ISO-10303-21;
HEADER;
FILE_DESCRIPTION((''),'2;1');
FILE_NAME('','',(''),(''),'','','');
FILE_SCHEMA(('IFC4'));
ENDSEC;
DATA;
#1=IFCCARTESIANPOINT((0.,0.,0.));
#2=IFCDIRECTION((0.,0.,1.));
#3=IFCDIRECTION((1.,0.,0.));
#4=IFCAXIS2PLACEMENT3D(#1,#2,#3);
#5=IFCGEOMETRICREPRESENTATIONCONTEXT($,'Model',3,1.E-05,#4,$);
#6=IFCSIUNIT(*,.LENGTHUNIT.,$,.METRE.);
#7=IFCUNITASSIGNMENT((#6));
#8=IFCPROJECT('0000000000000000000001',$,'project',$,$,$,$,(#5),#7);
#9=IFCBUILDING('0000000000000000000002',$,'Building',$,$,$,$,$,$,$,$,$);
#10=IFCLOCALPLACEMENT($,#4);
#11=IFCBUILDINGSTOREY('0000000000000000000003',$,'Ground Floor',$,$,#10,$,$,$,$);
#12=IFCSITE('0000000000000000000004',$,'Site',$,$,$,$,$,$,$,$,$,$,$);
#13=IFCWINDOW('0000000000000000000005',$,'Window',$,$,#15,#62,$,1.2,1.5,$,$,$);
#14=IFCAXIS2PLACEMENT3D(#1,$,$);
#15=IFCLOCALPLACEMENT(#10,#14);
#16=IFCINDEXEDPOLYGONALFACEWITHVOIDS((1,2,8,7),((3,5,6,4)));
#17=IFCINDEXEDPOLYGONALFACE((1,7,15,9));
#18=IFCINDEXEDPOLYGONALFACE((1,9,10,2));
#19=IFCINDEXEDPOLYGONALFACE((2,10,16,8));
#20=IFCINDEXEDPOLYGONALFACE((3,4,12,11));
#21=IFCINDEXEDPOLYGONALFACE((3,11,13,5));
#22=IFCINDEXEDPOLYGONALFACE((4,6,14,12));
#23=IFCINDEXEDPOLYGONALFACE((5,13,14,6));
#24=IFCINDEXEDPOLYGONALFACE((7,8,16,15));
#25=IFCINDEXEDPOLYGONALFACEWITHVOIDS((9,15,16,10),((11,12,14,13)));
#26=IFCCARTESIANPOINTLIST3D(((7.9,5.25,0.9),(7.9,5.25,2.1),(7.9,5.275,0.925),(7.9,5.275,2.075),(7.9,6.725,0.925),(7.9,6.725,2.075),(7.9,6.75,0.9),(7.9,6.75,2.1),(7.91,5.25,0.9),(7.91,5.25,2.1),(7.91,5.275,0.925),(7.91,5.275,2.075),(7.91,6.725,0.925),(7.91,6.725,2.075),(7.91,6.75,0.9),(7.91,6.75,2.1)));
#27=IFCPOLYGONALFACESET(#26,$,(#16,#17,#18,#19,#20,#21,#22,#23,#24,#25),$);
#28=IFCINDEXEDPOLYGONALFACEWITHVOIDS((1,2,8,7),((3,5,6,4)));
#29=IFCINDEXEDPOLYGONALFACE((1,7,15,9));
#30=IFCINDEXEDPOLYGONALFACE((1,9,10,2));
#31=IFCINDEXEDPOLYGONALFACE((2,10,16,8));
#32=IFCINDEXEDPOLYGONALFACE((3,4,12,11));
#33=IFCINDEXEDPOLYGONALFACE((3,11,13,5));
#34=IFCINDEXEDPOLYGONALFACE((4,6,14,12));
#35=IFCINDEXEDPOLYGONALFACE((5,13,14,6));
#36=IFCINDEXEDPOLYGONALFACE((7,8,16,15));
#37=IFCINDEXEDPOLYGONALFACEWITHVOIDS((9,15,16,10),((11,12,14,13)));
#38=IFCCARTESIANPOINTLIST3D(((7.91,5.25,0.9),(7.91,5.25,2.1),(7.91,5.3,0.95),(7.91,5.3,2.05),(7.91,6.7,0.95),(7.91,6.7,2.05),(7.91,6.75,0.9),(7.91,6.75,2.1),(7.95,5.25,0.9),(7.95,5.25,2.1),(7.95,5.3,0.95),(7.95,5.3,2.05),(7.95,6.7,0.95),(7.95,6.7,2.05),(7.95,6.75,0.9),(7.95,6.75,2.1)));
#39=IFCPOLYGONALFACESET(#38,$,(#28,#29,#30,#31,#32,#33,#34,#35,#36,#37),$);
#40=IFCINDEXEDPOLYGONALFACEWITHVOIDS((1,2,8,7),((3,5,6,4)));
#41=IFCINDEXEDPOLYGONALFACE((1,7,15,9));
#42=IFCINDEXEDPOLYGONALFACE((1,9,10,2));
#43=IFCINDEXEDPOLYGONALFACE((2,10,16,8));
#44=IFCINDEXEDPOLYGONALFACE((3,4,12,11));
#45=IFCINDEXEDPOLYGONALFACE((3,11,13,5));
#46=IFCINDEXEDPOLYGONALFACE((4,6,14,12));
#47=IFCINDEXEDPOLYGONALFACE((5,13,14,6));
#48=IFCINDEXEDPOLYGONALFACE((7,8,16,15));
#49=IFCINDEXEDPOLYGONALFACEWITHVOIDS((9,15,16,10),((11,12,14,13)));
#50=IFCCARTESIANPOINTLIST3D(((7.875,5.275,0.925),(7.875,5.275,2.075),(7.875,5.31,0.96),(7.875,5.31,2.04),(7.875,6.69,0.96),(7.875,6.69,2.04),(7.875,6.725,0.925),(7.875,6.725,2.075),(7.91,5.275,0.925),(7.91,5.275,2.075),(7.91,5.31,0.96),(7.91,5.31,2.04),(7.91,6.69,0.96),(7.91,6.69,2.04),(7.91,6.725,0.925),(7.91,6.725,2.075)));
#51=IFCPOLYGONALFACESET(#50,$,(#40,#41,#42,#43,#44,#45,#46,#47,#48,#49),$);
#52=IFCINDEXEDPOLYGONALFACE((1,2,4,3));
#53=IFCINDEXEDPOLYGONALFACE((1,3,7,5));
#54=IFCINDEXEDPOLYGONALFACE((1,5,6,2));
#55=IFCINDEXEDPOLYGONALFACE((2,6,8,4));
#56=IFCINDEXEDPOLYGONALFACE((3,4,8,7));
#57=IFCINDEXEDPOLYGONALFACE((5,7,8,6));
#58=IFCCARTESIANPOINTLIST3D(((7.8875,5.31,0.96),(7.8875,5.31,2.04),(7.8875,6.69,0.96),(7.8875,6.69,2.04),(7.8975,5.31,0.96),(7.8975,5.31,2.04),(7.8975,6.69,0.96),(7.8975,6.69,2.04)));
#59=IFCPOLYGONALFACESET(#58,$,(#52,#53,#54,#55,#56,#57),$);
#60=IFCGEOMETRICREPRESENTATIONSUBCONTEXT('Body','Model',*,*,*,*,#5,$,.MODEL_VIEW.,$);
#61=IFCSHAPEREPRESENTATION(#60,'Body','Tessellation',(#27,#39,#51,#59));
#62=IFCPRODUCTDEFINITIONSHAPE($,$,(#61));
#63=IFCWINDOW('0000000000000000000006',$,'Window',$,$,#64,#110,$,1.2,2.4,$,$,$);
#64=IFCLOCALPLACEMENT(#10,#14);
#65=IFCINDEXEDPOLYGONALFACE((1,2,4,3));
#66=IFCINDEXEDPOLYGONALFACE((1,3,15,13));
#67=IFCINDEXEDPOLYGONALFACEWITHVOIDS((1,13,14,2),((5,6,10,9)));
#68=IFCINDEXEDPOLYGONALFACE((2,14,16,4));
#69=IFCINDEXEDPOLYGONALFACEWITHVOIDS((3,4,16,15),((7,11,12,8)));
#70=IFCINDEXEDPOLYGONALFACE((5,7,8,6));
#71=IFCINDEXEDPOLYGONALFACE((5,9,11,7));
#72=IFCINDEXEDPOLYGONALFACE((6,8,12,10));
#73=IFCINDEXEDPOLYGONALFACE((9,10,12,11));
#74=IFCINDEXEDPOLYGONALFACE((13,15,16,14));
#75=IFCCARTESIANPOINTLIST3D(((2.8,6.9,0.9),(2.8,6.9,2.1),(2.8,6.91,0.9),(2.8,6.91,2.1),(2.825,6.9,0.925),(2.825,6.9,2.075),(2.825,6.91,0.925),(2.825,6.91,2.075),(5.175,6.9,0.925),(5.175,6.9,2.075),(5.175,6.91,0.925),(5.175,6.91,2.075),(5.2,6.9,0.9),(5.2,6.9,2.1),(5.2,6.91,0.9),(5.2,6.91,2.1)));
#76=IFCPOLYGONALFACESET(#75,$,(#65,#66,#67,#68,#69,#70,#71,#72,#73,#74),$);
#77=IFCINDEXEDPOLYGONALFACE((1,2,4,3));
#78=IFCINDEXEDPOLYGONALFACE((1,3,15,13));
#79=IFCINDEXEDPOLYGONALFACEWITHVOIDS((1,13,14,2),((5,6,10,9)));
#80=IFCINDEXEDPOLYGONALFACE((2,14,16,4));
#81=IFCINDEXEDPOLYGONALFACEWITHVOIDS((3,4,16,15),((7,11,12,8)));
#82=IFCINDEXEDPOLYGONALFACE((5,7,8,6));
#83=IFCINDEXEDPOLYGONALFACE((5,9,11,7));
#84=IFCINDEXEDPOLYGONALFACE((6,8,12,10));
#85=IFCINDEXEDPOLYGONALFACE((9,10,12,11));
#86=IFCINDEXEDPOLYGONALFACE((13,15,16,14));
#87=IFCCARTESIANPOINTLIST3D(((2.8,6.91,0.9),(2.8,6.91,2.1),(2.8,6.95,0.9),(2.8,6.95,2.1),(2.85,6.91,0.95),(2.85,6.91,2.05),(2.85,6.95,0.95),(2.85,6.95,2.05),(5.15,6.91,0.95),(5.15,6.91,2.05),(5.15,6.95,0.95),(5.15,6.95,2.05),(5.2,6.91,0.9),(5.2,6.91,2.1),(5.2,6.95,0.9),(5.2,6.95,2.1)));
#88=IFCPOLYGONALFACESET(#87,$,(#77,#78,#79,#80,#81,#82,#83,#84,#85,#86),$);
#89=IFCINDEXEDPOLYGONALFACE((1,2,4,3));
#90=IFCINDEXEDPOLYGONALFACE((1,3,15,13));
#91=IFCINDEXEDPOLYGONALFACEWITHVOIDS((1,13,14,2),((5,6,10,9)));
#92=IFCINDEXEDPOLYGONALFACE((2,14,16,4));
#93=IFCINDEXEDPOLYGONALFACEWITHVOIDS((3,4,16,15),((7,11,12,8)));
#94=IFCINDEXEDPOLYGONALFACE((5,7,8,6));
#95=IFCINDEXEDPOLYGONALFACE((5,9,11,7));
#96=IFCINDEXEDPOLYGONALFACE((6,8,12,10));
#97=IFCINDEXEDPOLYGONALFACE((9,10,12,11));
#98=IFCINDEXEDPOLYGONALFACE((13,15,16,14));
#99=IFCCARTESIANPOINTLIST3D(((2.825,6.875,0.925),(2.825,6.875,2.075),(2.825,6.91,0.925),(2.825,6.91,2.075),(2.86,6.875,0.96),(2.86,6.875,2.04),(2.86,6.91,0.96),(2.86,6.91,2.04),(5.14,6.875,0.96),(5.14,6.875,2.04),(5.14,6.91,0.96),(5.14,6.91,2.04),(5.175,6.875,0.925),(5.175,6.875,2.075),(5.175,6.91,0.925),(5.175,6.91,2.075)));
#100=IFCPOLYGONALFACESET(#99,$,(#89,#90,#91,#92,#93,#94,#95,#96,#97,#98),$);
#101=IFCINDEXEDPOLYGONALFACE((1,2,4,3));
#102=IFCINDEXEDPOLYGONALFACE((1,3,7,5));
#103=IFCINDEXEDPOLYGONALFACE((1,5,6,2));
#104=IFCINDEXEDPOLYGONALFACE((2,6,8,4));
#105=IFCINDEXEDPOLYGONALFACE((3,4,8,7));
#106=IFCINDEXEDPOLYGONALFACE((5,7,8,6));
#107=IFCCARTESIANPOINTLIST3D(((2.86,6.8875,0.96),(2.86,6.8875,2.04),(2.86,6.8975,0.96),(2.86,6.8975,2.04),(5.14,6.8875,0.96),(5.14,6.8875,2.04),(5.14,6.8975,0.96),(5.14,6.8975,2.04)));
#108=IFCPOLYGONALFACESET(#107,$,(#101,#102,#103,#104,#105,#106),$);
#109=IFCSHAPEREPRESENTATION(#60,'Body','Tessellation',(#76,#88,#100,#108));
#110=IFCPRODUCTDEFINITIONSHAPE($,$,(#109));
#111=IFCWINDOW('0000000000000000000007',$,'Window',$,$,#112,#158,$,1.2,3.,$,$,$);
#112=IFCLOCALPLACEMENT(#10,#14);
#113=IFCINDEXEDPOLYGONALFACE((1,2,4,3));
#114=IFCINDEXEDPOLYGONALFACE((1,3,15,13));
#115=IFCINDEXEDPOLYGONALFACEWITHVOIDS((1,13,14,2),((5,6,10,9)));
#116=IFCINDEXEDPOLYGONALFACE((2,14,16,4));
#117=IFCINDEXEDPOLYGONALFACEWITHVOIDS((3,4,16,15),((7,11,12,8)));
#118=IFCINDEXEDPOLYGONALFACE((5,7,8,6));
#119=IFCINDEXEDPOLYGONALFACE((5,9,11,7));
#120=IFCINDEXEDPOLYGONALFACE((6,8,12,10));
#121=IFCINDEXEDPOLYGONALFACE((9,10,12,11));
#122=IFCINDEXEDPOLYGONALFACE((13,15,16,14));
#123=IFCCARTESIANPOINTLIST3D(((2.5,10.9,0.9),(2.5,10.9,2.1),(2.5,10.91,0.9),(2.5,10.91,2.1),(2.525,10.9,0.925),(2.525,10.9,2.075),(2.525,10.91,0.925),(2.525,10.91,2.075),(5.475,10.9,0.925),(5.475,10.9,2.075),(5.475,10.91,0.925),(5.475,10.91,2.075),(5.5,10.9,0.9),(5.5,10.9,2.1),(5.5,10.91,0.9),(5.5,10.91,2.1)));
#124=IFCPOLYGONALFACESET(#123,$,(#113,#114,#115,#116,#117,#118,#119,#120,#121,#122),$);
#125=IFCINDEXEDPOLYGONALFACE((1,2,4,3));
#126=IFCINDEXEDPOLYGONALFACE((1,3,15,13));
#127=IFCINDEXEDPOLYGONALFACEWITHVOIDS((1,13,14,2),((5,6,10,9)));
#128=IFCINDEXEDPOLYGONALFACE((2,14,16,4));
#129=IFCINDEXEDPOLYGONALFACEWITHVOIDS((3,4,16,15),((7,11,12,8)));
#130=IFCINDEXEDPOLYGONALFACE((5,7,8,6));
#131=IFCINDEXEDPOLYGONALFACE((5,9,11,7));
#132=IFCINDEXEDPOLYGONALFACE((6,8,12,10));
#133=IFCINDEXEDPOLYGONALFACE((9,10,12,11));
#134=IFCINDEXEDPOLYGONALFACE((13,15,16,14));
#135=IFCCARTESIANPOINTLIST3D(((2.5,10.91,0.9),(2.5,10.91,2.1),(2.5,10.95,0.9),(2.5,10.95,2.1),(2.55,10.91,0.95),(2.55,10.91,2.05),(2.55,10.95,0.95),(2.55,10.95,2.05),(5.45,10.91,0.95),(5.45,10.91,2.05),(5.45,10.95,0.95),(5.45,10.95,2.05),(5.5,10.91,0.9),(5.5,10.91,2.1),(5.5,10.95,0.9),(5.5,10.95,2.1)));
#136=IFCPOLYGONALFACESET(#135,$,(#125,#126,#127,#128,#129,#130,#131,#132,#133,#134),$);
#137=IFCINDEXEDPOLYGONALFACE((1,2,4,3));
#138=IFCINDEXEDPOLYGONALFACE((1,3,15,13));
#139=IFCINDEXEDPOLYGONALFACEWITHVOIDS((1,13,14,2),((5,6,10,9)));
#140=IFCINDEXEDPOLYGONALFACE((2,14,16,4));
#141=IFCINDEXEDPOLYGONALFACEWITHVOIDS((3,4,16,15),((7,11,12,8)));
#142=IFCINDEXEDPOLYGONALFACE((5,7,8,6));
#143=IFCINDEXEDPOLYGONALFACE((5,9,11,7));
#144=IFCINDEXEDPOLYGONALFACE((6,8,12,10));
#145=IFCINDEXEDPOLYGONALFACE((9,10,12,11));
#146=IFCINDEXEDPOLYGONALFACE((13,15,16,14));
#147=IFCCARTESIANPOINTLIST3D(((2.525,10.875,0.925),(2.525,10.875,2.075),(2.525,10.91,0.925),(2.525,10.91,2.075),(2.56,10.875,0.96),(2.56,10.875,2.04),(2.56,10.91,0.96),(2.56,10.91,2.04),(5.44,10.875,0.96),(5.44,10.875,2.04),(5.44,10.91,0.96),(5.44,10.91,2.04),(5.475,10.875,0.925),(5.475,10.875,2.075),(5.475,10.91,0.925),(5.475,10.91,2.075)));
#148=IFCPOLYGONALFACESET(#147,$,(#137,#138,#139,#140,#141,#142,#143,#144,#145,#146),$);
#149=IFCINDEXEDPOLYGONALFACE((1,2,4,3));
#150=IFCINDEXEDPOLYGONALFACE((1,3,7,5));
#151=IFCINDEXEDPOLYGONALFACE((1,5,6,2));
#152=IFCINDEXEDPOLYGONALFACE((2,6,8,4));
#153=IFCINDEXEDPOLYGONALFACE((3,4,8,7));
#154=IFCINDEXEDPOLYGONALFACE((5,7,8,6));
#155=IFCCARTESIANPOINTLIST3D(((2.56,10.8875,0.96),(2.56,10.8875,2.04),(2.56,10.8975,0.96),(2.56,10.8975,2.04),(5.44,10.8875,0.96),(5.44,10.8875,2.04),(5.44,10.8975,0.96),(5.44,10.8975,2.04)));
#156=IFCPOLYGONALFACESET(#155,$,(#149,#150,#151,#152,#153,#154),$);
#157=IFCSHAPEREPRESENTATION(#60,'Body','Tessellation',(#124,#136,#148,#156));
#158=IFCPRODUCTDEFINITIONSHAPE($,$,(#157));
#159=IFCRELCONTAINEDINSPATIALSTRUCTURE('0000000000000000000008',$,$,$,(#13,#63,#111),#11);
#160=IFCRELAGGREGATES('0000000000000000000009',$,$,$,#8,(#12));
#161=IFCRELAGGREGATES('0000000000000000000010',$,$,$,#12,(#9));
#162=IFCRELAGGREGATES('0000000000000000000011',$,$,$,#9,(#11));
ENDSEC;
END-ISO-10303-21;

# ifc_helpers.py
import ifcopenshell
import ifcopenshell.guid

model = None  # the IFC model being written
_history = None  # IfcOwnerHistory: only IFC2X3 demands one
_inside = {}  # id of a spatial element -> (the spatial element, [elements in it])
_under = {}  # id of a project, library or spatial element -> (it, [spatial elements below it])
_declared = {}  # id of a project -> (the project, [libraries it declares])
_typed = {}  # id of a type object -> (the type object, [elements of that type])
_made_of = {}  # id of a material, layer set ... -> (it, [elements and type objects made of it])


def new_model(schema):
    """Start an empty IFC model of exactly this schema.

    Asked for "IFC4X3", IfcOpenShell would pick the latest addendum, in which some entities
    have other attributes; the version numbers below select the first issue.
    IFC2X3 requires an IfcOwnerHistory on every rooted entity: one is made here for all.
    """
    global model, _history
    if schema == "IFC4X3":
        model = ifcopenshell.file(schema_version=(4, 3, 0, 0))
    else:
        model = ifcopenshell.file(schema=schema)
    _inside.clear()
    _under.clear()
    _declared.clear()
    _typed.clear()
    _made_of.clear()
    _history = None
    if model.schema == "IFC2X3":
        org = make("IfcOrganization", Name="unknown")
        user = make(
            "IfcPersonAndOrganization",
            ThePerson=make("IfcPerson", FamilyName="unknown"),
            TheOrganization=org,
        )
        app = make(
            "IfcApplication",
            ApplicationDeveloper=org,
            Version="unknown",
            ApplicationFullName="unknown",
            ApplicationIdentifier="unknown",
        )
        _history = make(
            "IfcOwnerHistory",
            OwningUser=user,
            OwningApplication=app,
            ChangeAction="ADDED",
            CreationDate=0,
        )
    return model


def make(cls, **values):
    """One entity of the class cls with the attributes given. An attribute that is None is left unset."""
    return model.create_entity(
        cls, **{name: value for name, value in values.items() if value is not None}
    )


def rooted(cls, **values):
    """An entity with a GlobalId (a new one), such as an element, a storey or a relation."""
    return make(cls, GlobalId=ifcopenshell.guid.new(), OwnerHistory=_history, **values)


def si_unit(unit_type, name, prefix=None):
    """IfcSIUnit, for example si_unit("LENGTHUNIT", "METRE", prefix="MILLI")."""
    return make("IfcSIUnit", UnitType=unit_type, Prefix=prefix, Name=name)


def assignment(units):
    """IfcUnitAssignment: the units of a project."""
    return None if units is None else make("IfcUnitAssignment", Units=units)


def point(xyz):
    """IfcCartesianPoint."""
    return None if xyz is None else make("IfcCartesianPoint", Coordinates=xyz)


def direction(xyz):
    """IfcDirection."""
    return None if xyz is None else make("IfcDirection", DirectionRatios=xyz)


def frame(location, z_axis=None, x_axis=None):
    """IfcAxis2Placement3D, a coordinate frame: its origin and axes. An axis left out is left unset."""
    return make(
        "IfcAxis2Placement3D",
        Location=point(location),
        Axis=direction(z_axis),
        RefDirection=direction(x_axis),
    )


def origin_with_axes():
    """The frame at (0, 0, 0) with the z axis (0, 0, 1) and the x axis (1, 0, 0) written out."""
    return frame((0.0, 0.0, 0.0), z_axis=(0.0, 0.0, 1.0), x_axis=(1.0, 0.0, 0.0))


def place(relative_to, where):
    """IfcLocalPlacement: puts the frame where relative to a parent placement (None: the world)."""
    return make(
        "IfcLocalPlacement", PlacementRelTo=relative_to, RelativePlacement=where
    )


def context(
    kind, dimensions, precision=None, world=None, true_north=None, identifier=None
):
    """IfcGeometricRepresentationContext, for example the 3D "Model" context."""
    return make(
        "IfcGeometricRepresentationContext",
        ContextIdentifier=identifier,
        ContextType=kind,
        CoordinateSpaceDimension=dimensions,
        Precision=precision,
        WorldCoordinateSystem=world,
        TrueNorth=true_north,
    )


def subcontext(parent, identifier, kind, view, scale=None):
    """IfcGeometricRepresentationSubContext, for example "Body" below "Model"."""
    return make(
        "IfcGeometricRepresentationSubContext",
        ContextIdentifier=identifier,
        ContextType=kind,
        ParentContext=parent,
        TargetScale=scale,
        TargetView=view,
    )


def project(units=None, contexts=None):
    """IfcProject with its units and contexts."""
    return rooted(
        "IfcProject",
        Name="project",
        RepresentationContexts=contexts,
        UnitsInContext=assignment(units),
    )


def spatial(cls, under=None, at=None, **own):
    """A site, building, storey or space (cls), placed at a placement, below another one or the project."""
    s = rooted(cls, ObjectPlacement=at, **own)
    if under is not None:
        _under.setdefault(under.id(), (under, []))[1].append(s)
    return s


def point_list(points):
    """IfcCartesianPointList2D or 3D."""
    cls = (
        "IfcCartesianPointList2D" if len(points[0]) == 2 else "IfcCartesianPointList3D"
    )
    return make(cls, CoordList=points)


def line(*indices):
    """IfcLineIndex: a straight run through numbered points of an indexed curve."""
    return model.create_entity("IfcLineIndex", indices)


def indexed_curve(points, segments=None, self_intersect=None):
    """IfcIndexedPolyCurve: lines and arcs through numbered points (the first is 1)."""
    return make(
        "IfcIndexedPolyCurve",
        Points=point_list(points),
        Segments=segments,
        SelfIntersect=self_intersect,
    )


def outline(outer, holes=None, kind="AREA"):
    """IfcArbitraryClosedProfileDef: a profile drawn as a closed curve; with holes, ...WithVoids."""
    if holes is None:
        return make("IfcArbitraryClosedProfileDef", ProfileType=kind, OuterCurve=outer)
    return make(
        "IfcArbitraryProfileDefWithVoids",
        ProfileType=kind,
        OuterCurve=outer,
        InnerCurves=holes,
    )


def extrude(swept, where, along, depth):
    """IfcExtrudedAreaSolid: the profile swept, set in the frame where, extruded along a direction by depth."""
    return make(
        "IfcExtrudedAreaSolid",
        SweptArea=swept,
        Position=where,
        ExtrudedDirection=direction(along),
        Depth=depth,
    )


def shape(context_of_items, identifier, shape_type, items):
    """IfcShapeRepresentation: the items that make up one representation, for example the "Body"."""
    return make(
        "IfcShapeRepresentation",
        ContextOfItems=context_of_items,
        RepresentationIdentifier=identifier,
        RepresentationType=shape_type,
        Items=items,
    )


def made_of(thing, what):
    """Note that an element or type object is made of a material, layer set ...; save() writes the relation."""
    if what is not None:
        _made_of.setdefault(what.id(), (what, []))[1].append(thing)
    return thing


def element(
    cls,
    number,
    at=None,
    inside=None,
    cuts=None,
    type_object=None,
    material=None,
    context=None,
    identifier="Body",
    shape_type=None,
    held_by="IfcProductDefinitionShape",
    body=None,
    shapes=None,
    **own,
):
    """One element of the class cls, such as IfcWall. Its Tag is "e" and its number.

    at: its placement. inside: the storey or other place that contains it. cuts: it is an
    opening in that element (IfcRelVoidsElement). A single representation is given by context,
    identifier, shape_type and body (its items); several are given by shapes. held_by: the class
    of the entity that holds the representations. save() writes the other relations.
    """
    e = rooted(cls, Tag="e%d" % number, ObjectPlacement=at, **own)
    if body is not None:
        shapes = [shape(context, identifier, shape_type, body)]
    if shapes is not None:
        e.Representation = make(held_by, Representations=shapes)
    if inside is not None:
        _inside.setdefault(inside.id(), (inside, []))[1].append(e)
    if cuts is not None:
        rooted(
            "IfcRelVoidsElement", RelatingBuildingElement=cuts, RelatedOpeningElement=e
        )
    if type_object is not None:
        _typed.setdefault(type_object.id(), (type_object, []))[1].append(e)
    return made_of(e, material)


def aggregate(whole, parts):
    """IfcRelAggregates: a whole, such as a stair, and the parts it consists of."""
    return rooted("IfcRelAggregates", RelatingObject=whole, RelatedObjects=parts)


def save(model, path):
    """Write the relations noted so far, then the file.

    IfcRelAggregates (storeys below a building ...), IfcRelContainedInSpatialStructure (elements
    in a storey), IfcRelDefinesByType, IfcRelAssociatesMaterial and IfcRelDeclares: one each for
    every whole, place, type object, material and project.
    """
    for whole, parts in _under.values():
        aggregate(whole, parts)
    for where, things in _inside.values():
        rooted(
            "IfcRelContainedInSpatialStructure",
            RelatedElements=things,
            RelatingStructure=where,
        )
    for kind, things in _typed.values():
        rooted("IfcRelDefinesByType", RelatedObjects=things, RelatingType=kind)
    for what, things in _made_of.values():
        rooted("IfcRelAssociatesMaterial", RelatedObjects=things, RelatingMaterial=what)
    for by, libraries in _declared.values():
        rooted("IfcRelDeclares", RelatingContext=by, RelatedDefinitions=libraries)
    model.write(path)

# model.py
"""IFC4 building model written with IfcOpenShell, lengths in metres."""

from ifc_helpers import new_model, si_unit, frame, origin_with_axes, place, context, subcontext, project, spatial, line, indexed_curve, outline, extrude, element, save


model = new_model("IFC4")

# Units and contexts
model_context = context("Model", 3, precision=1e-05, world=origin_with_axes())
body_context = subcontext(model_context, "Body", "Model", "MODEL_VIEW")
ifc_project = project(units=[si_unit("LENGTHUNIT", "METRE")], contexts=[model_context])

# Site, building, storey
site = spatial("IfcSite", under=ifc_project, Name="Site")
building = spatial("IfcBuilding", under=site, Name="Building")
storey_placement = place(None, origin_with_axes())
storey = spatial("IfcBuildingStorey", under=building, at=storey_placement, Name="Ground Floor")

# Windows
window_1_placement = place(storey_placement, frame((8.0, 5.25, 0.9), z_axis=(0.0, 0.0, 1.0), x_axis=(0.0, 1.0, 0.0)))
element("IfcWindow", 1, at=window_1_placement, inside=storey, Name="Window", OverallHeight=1.2, OverallWidth=1.5, context=body_context, shape_type="SweptSolid", body=[
    extrude(outline(indexed_curve([(0.0, 0.0), (1.5, 0.0), (1.5, 1.2), (0.0, 1.2)], segments=[line(1, 2, 3, 4, 1)]), holes=[indexed_curve([(0.025, 0.025), (1.475, 0.025), (1.475, 1.175), (0.025, 1.175)], segments=[line(1, 2, 3, 4, 1)])]), frame((0.0, 0.09, 0.0), z_axis=(0.0, -1.0, 0.0), x_axis=(1.0, 0.0, 0.0)), (0.0, 0.0, -1.0), 0.01),
    extrude(outline(indexed_curve([(0.0, 0.0), (1.5, 0.0), (1.5, 1.2), (0.0, 1.2)], segments=[line(1, 2, 3, 4, 1)]), holes=[indexed_curve([(0.05, 0.05), (1.45, 0.05), (1.45, 1.15), (0.05, 1.15)], segments=[line(1, 2, 3, 4, 1)])]), frame((0.0, 0.05, 0.0), z_axis=(0.0, -1.0, 0.0), x_axis=(1.0, 0.0, 0.0)), (0.0, 0.0, -1.0), 0.04),
    extrude(outline(indexed_curve([(0.0, 0.0), (1.45, 0.0), (1.45, 1.15), (0.0, 1.15)], segments=[line(1, 2, 3, 4, 1)]), holes=[indexed_curve([(0.035, 0.035), (1.415, 0.035), (1.415, 1.115), (0.035, 1.115)], segments=[line(1, 2, 3, 4, 1)])]), frame((0.025, 0.09, 0.025), z_axis=(0.0, -1.0, 0.0), x_axis=(1.0, 0.0, 0.0)), (0.0, 0.0, -1.0), 0.035),
    extrude(outline(indexed_curve([(0.035, 0.035), (1.415, 0.035), (1.415, 1.115), (0.035, 1.115)], segments=[line(1, 2, 3, 4, 1)])), frame((0.025, 0.1025, 0.025), z_axis=(0.0, -1.0, 0.0), x_axis=(1.0, 0.0, 0.0)), (0.0, 0.0, -1.0), 0.01),
])
window_2_placement = place(storey_placement, frame((5.2, 7.0, 0.9), z_axis=(0.0, 0.0, 1.0), x_axis=(-1.0, 0.0, 0.0)))
element("IfcWindow", 2, at=window_2_placement, inside=storey, Name="Window", OverallHeight=1.2, OverallWidth=2.4, context=body_context, shape_type="SweptSolid", body=[
    extrude(outline(indexed_curve([(0.0, 0.0), (2.4, 0.0), (2.4, 1.2), (0.0, 1.2)], segments=[line(1, 2, 3, 4, 1)]), holes=[indexed_curve([(0.025, 0.025), (2.375, 0.025), (2.375, 1.175), (0.025, 1.175)], segments=[line(1, 2, 3, 4, 1)])]), frame((0.0, 0.09, 0.0), z_axis=(0.0, -1.0, 0.0), x_axis=(1.0, 0.0, 0.0)), (0.0, 0.0, -1.0), 0.01),
    extrude(outline(indexed_curve([(0.0, 0.0), (2.4, 0.0), (2.4, 1.2), (0.0, 1.2)], segments=[line(1, 2, 3, 4, 1)]), holes=[indexed_curve([(0.05, 0.05), (2.35, 0.05), (2.35, 1.15), (0.05, 1.15)], segments=[line(1, 2, 3, 4, 1)])]), frame((0.0, 0.05, 0.0), z_axis=(0.0, -1.0, 0.0), x_axis=(1.0, 0.0, 0.0)), (0.0, 0.0, -1.0), 0.04),
    extrude(outline(indexed_curve([(0.0, 0.0), (2.35, 0.0), (2.35, 1.15), (0.0, 1.15)], segments=[line(1, 2, 3, 4, 1)]), holes=[indexed_curve([(0.035, 0.035), (2.315, 0.035), (2.315, 1.115), (0.035, 1.115)], segments=[line(1, 2, 3, 4, 1)])]), frame((0.025, 0.09, 0.025), z_axis=(0.0, -1.0, 0.0), x_axis=(1.0, 0.0, 0.0)), (0.0, 0.0, -1.0), 0.035),
    extrude(outline(indexed_curve([(0.035, 0.035), (2.315, 0.035), (2.315, 1.115), (0.035, 1.115)], segments=[line(1, 2, 3, 4, 1)])), frame((0.025, 0.1025, 0.025), z_axis=(0.0, -1.0, 0.0), x_axis=(1.0, 0.0, 0.0)), (0.0, 0.0, -1.0), 0.01),
])
window_3_placement = place(storey_placement, frame((5.5, 11.0, 0.9), z_axis=(0.0, 0.0, 1.0), x_axis=(-1.0, 0.0, 0.0)))
element("IfcWindow", 3, at=window_3_placement, inside=storey, Name="Window", OverallHeight=1.2, OverallWidth=3.0, context=body_context, shape_type="SweptSolid", body=[
    extrude(outline(indexed_curve([(0.0, 0.0), (3.0, 0.0), (3.0, 1.2), (0.0, 1.2)], segments=[line(1, 2, 3, 4, 1)]), holes=[indexed_curve([(0.025, 0.025), (2.975, 0.025), (2.975, 1.175), (0.025, 1.175)], segments=[line(1, 2, 3, 4, 1)])]), frame((0.0, 0.09, 0.0), z_axis=(0.0, -1.0, 0.0), x_axis=(1.0, 0.0, 0.0)), (0.0, 0.0, -1.0), 0.01),
    extrude(outline(indexed_curve([(0.0, 0.0), (3.0, 0.0), (3.0, 1.2), (0.0, 1.2)], segments=[line(1, 2, 3, 4, 1)]), holes=[indexed_curve([(0.05, 0.05), (2.95, 0.05), (2.95, 1.15), (0.05, 1.15)], segments=[line(1, 2, 3, 4, 1)])]), frame((0.0, 0.05, 0.0), z_axis=(0.0, -1.0, 0.0), x_axis=(1.0, 0.0, 0.0)), (0.0, 0.0, -1.0), 0.04),
    extrude(outline(indexed_curve([(0.0, 0.0), (2.95, 0.0), (2.95, 1.15), (0.0, 1.15)], segments=[line(1, 2, 3, 4, 1)]), holes=[indexed_curve([(0.035, 0.035), (2.915, 0.035), (2.915, 1.115), (0.035, 1.115)], segments=[line(1, 2, 3, 4, 1)])]), frame((0.025, 0.09, 0.025), z_axis=(0.0, -1.0, 0.0), x_axis=(1.0, 0.0, 0.0)), (0.0, 0.0, -1.0), 0.035),
    extrude(outline(indexed_curve([(0.035, 0.035), (2.915, 0.035), (2.915, 1.115), (0.035, 1.115)], segments=[line(1, 2, 3, 4, 1)])), frame((0.025, 0.1025, 0.025), z_axis=(0.0, -1.0, 0.0), x_axis=(1.0, 0.0, 0.0)), (0.0, 0.0, -1.0), 0.01),
])

save(model, "model.ifc")
